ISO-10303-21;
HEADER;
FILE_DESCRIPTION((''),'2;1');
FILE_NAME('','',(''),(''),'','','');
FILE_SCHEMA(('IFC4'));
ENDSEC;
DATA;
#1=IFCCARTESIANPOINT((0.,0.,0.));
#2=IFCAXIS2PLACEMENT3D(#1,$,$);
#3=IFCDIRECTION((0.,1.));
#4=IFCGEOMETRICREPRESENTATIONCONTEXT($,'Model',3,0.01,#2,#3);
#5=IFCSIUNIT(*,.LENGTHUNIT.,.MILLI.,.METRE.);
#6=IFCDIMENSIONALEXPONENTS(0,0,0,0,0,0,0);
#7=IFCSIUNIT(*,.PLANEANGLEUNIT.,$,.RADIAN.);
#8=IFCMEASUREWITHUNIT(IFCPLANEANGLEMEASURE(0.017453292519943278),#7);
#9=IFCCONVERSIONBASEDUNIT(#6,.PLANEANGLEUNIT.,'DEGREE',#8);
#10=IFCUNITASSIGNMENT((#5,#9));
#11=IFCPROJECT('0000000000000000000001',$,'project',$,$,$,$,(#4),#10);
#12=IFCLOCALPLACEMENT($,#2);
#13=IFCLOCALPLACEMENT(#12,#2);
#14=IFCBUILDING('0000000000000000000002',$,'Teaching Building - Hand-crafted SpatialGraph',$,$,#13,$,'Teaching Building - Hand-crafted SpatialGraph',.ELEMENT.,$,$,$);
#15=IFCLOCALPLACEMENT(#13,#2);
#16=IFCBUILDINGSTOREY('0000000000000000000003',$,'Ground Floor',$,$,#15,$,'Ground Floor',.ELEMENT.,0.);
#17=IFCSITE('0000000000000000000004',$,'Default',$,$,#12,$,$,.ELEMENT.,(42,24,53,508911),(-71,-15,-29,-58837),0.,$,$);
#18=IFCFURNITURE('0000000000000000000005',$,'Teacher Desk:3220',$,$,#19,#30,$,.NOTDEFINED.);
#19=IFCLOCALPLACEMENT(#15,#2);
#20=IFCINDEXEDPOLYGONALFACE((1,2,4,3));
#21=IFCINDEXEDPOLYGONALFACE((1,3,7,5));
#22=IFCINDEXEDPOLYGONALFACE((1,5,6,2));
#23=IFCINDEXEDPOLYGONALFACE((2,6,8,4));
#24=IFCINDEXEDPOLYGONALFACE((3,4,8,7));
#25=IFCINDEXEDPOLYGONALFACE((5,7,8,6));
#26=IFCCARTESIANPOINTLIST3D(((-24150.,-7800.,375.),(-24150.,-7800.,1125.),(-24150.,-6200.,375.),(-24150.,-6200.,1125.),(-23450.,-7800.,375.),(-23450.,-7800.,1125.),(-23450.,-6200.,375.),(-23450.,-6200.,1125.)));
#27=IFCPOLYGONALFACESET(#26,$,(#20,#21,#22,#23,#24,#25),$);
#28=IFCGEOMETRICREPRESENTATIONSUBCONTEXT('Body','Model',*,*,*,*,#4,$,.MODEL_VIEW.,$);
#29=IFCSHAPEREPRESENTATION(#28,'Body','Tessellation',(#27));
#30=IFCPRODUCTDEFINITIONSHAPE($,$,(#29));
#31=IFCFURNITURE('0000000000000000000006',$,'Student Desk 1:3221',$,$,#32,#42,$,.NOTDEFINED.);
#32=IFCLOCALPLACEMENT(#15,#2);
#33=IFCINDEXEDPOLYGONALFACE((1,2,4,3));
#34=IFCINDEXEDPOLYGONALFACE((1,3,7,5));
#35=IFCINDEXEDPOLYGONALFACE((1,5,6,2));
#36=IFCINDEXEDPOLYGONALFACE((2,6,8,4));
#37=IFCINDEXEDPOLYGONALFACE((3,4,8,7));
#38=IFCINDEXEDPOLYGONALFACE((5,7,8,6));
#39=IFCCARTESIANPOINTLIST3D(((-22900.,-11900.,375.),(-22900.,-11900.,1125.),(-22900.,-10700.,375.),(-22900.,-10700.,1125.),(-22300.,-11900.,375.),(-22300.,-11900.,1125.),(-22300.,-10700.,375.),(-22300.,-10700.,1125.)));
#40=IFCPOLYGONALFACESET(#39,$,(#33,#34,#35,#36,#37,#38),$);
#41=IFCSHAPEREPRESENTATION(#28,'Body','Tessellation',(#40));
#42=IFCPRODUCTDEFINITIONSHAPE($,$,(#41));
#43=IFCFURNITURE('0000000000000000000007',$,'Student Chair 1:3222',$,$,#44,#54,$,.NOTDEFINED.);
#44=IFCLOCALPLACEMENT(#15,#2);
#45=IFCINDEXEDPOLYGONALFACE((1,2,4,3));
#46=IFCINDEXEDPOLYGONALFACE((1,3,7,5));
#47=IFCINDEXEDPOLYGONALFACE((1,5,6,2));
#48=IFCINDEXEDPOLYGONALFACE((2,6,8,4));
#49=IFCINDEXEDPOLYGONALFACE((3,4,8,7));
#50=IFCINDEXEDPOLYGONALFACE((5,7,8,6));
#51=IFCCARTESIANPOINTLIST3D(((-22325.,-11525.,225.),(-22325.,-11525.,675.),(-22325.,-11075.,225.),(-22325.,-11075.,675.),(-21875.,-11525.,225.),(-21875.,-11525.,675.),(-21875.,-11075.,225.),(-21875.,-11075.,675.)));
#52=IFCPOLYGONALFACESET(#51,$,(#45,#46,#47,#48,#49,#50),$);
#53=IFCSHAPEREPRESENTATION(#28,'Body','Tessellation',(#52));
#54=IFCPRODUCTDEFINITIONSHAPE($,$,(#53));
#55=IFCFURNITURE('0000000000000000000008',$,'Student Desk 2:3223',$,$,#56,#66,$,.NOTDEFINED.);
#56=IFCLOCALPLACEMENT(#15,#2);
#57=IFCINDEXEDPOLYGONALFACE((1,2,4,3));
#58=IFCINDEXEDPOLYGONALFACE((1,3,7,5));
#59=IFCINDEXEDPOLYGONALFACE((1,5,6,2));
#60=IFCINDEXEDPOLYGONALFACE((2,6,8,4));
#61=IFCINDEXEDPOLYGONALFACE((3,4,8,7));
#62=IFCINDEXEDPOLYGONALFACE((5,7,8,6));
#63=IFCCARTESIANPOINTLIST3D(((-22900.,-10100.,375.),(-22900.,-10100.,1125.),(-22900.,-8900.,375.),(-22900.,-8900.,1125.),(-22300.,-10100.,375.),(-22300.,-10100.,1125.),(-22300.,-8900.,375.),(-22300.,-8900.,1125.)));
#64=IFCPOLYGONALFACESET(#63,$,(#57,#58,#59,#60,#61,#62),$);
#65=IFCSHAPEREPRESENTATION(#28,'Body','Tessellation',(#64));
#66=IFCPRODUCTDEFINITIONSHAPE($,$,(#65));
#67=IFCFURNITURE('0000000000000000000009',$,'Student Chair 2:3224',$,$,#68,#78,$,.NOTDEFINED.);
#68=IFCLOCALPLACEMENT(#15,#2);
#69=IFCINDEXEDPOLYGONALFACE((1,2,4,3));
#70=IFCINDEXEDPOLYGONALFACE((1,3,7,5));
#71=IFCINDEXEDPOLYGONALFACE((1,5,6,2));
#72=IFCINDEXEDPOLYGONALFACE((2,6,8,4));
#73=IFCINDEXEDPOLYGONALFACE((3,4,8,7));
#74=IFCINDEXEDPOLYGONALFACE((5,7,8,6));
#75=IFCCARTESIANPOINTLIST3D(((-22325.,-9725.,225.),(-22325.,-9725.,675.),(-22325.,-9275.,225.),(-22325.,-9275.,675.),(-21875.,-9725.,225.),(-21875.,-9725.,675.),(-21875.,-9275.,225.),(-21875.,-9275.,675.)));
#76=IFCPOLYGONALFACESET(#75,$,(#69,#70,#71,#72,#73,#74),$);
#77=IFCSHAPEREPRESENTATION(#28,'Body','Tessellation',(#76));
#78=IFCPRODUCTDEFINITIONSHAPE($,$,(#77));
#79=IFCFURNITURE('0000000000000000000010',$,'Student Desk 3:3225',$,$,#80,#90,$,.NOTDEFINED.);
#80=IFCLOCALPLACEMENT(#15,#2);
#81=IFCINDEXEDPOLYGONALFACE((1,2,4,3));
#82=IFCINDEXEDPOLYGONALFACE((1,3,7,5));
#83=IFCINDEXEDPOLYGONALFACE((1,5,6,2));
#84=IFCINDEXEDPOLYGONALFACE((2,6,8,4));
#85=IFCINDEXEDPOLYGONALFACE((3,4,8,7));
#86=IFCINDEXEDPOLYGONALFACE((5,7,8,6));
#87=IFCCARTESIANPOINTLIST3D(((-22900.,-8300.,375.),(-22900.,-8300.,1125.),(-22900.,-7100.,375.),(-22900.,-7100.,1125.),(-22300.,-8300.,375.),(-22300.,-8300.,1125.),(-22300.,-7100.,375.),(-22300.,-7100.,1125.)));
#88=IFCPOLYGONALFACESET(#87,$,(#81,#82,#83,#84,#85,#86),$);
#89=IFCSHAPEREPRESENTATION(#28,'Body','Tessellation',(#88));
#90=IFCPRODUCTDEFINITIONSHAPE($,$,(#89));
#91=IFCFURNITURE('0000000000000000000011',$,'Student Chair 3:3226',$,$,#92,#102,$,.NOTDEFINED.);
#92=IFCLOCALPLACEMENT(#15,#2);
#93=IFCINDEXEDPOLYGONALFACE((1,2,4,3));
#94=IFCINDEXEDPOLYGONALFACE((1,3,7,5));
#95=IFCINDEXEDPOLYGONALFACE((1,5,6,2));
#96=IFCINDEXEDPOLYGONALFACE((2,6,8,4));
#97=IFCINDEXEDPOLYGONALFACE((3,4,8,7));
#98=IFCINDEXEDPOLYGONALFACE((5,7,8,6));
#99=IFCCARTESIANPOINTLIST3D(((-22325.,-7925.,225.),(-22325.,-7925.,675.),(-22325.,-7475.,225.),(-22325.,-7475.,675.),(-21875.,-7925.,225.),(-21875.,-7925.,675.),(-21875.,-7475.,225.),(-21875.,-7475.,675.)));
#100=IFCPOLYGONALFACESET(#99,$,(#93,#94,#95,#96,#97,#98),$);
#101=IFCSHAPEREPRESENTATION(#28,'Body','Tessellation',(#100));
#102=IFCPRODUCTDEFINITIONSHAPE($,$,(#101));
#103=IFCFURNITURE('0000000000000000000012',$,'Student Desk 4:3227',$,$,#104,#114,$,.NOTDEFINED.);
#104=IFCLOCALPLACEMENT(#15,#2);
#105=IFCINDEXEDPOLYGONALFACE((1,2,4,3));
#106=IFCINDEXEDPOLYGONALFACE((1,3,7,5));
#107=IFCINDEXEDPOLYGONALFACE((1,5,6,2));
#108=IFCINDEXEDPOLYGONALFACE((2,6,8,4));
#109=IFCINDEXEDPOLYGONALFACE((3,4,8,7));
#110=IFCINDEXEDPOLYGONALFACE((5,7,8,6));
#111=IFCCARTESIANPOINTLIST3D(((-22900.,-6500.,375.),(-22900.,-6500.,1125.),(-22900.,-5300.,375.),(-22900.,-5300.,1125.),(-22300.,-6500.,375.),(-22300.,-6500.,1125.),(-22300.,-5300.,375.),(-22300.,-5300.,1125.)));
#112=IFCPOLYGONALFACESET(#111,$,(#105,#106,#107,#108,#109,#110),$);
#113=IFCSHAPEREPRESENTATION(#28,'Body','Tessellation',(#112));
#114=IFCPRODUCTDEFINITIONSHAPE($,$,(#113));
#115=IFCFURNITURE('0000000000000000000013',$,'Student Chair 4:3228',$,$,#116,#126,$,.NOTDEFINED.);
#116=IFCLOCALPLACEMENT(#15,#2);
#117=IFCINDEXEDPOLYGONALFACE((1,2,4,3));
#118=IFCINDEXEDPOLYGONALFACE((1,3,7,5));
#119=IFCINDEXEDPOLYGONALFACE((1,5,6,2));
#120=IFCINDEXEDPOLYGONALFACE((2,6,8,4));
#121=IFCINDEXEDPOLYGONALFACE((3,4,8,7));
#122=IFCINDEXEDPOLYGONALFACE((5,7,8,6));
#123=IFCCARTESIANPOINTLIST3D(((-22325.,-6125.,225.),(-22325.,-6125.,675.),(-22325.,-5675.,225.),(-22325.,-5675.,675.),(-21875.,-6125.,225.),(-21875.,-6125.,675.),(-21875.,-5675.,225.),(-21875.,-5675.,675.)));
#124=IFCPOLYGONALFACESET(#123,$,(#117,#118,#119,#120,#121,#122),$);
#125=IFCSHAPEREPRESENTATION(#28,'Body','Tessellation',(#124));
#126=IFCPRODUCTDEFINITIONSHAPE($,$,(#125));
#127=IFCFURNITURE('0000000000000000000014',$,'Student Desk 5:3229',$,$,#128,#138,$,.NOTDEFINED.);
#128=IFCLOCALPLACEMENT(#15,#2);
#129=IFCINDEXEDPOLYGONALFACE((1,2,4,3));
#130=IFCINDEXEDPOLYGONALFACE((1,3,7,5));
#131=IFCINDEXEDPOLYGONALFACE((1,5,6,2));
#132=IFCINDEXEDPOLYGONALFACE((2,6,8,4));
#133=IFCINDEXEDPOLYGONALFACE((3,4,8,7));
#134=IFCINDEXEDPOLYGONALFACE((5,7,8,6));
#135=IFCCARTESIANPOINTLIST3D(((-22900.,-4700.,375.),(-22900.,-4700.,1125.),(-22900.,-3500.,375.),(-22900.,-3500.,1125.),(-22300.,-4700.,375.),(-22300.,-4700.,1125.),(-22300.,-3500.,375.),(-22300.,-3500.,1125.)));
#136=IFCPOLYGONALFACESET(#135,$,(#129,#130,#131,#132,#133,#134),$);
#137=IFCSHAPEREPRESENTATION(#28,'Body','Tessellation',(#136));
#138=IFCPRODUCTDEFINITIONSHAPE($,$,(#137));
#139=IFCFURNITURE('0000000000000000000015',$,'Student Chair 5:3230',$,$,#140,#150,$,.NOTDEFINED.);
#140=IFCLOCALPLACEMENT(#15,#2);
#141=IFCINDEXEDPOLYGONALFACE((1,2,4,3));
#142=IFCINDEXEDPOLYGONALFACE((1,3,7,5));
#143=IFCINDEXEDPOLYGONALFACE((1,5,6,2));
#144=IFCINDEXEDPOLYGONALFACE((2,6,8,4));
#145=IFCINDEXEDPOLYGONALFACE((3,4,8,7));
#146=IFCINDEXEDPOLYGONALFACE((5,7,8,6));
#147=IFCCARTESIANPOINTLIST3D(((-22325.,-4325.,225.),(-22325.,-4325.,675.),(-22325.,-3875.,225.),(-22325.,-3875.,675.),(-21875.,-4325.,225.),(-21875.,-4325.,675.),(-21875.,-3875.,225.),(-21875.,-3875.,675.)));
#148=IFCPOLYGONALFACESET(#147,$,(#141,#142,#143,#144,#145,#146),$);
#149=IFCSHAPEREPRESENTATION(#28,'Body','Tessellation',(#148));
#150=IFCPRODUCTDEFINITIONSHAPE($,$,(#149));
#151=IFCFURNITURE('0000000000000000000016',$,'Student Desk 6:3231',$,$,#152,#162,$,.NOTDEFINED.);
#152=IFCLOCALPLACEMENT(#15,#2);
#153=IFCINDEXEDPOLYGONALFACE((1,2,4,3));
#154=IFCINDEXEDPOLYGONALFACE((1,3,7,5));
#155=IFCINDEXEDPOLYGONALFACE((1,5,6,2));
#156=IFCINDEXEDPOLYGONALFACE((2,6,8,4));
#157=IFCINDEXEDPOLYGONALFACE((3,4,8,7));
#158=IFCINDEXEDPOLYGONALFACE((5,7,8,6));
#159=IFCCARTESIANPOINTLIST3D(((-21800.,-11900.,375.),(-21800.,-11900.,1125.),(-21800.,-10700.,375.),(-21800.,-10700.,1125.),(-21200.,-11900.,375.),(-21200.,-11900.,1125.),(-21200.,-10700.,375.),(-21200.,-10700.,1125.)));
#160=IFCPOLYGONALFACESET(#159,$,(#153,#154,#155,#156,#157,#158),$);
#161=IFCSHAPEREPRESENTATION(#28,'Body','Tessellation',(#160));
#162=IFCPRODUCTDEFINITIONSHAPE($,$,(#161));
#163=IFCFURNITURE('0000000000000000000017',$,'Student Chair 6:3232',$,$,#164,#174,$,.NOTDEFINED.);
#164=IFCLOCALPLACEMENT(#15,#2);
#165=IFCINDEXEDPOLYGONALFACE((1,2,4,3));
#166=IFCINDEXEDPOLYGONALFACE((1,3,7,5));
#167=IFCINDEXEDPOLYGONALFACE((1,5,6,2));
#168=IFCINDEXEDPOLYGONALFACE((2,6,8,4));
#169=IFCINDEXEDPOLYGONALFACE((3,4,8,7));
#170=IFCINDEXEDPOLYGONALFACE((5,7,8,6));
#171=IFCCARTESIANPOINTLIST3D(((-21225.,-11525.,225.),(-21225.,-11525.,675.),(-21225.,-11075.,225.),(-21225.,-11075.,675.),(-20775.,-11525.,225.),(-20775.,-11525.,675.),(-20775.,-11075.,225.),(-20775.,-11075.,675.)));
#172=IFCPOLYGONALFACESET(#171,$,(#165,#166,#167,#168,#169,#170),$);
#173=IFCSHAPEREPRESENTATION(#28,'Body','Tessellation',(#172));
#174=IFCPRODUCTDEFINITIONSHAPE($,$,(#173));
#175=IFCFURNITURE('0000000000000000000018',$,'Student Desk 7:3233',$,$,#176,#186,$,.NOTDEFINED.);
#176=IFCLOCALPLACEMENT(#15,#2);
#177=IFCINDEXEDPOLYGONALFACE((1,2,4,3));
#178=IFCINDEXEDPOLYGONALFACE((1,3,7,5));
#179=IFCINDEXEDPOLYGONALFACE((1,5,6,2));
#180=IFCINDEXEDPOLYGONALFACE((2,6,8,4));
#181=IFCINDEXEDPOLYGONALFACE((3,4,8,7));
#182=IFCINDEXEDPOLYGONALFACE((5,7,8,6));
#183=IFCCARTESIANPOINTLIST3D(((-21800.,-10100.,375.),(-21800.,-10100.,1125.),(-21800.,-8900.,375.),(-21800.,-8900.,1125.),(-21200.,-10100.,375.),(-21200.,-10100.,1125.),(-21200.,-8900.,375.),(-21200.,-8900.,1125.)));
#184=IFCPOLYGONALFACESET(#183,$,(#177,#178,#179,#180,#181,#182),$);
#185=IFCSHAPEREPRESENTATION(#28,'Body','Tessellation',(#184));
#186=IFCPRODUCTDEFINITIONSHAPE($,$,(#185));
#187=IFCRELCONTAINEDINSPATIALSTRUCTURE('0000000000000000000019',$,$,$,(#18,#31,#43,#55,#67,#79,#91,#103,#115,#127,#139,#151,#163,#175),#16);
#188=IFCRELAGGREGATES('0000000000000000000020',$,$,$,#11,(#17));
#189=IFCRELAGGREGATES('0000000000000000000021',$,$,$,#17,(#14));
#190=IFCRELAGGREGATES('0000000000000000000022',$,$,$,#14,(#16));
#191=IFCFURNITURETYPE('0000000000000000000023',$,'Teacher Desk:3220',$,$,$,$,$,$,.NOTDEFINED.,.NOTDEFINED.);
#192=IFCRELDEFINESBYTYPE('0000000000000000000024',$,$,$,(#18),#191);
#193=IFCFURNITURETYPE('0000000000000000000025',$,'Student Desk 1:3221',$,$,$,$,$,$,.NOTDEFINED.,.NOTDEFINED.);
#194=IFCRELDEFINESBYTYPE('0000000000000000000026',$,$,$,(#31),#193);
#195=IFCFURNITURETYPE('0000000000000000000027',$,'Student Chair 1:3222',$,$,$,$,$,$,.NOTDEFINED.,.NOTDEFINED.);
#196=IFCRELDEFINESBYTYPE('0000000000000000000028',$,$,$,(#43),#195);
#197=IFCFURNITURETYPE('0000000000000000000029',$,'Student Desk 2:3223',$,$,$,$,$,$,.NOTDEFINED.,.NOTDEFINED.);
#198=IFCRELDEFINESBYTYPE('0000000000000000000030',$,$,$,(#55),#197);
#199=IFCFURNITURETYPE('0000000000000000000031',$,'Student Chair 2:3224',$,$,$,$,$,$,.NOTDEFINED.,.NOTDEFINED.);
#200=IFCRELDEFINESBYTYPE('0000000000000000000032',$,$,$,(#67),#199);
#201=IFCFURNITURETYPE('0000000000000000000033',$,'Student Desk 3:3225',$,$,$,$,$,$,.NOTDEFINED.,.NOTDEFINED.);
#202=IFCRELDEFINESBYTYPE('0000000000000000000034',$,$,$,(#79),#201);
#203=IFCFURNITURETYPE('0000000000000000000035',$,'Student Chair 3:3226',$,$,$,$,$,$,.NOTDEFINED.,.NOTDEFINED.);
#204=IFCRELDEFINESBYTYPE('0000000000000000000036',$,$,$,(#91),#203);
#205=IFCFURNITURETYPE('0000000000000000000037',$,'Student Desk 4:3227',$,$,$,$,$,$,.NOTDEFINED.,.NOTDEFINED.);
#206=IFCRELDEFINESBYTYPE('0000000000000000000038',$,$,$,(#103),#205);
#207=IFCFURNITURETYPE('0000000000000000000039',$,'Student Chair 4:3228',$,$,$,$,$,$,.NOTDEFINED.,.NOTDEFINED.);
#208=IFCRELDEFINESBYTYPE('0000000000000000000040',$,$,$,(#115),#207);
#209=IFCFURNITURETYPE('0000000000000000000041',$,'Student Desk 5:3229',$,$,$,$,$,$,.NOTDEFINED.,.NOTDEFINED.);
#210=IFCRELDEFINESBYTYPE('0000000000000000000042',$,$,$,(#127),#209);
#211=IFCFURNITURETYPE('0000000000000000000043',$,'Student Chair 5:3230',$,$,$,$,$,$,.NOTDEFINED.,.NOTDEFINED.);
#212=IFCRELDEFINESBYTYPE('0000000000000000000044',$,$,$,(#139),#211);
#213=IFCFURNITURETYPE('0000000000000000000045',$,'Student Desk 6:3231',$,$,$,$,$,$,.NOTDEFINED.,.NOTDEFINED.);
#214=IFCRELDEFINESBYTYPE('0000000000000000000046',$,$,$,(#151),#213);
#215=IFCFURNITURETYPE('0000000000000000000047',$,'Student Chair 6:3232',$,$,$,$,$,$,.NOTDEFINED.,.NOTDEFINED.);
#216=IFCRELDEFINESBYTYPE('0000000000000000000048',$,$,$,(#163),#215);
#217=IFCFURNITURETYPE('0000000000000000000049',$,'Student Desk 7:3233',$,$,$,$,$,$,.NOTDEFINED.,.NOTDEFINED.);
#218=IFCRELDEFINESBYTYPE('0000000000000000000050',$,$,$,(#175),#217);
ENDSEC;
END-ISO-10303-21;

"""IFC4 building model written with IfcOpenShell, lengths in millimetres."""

from ifc_helpers import new_model, entity, si_unit, converted_unit, direction, frame, frame_2d, origin, origin_2d_with_axis, place, context, subcontext, project, spatial, rectangle, extrude, type_object, element, save


model = new_model("IFC4")

# Units and contexts
model_context = context("Model", 3, precision=0.01, world=origin(), true_north=direction((0.0, 1.0)))
body_context = subcontext(model_context, "Body", "Model", "MODEL_VIEW")
ifc_project = project(units=[si_unit("LENGTHUNIT", "METRE", prefix="MILLI"), converted_unit("PLANEANGLEUNIT", "DEGREE", entity("IfcPlaneAngleMeasure", 0.017453292519943278), si_unit("PLANEANGLEUNIT", "RADIAN"), dimensions=[0, 0, 0, 0, 0, 0, 0])], contexts=[model_context])

# Site, building, storey
site_placement = place(None, origin())
site = spatial("IfcSite", under=ifc_project, at=site_placement, Name="Default", CompositionType="ELEMENT", RefLatitude=(42, 24, 53, 508911), RefLongitude=(-71, -15, -29, -58837), RefElevation=0.0)
building_placement = place(site_placement, origin())
building = spatial("IfcBuilding", under=site, at=building_placement, Name="Teaching Building - Hand-crafted SpatialGraph", LongName="Teaching Building - Hand-crafted SpatialGraph", CompositionType="ELEMENT")
storey_placement = place(building_placement, origin())
storey = spatial("IfcBuildingStorey", under=building, at=storey_placement, Name="Ground Floor", LongName="Ground Floor", CompositionType="ELEMENT", Elevation=0.0)

# Furniture
furniture_type_1 = type_object("IfcFurnitureType", Name="Teacher Desk:3220", PredefinedType="NOTDEFINED")
furniture_1_placement = place(storey_placement, origin())
element("IfcFurniture", 1, at=furniture_1_placement, inside=storey, type_object=furniture_type_1, Name="Teacher Desk:3220", PredefinedType="NOTDEFINED", context=body_context, shape_type="SweptSolid", body=[
    extrude(rectangle(XDim=1600.0, YDim=700.0, at=origin_2d_with_axis()), frame((-23800.0, -7000.0, 375.0), z_axis=(0.0, 0.0, 1.0), x_axis=(0.0, 1.0, 0.0)), (0.0, 0.0, 1.0), 750.0),
])
furniture_type_2 = type_object("IfcFurnitureType", Name="Student Desk 1:3221", PredefinedType="NOTDEFINED")
furniture_2_placement = place(storey_placement, origin())
element("IfcFurniture", 2, at=furniture_2_placement, inside=storey, type_object=furniture_type_2, Name="Student Desk 1:3221", PredefinedType="NOTDEFINED", context=body_context, shape_type="SweptSolid", body=[
    extrude(rectangle(XDim=1200.0, YDim=600.0, at=origin_2d_with_axis()), frame((-22600.0, -11300.0, 375.0), z_axis=(0.0, 0.0, 1.0), x_axis=(0.0, 1.0, 0.0)), (0.0, 0.0, 1.0), 750.0),
])
furniture_type_3 = type_object("IfcFurnitureType", Name="Student Chair 1:3222", PredefinedType="NOTDEFINED")
furniture_3_placement = place(storey_placement, origin())
element("IfcFurniture", 3, at=furniture_3_placement, inside=storey, type_object=furniture_type_3, Name="Student Chair 1:3222", PredefinedType="NOTDEFINED", context=body_context, shape_type="SweptSolid", body=[
    extrude(rectangle(XDim=450.0, YDim=450.0, at=origin_2d_with_axis()), frame((-22100.0, -11300.0, 225.0)), (0.0, 0.0, 1.0), 450.0),
])
furniture_type_4 = type_object("IfcFurnitureType", Name="Student Desk 2:3223", PredefinedType="NOTDEFINED")
furniture_4_placement = place(storey_placement, origin())
element("IfcFurniture", 4, at=furniture_4_placement, inside=storey, type_object=furniture_type_4, Name="Student Desk 2:3223", PredefinedType="NOTDEFINED", context=body_context, shape_type="SweptSolid", body=[
    extrude(rectangle(XDim=1200.0, YDim=600.0, at=origin_2d_with_axis()), frame((-22600.0, -9500.0, 375.0), z_axis=(0.0, 0.0, 1.0), x_axis=(0.0, 1.0, 0.0)), (0.0, 0.0, 1.0), 750.0),
])
furniture_type_5 = type_object("IfcFurnitureType", Name="Student Chair 2:3224", PredefinedType="NOTDEFINED")
furniture_5_placement = place(storey_placement, origin())
element("IfcFurniture", 5, at=furniture_5_placement, inside=storey, type_object=furniture_type_5, Name="Student Chair 2:3224", PredefinedType="NOTDEFINED", context=body_context, shape_type="SweptSolid", body=[
    extrude(rectangle(XDim=450.0, YDim=450.0, at=origin_2d_with_axis()), frame((-22100.0, -9500.0, 225.0)), (0.0, 0.0, 1.0), 450.0),
])
furniture_type_6 = type_object("IfcFurnitureType", Name="Student Desk 3:3225", PredefinedType="NOTDEFINED")
furniture_6_placement = place(storey_placement, origin())
element("IfcFurniture", 6, at=furniture_6_placement, inside=storey, type_object=furniture_type_6, Name="Student Desk 3:3225", PredefinedType="NOTDEFINED", context=body_context, shape_type="SweptSolid", body=[
    extrude(rectangle(XDim=1200.0, YDim=600.0, at=origin_2d_with_axis()), frame((-22600.0, -7700.0, 375.0), z_axis=(0.0, 0.0, 1.0), x_axis=(0.0, 1.0, 0.0)), (0.0, 0.0, 1.0), 750.0),
])
furniture_type_7 = type_object("IfcFurnitureType", Name="Student Chair 3:3226", PredefinedType="NOTDEFINED")
furniture_7_placement = place(storey_placement, origin())
element("IfcFurniture", 7, at=furniture_7_placement, inside=storey, type_object=furniture_type_7, Name="Student Chair 3:3226", PredefinedType="NOTDEFINED", context=body_context, shape_type="SweptSolid", body=[
    extrude(rectangle(XDim=450.0, YDim=450.0, at=frame_2d((0.0, 0.0), x_axis=(1.0, 0.0))), frame((-22100.0, -7700.0, 225.0)), (0.0, 0.0, 1.0), 450.0),
])
furniture_type_8 = type_object("IfcFurnitureType", Name="Student Desk 4:3227", PredefinedType="NOTDEFINED")
furniture_8_placement = place(storey_placement, origin())
element("IfcFurniture", 8, at=furniture_8_placement, inside=storey, type_object=furniture_type_8, Name="Student Desk 4:3227", PredefinedType="NOTDEFINED", context=body_context, shape_type="SweptSolid", body=[
    extrude(rectangle(XDim=1200.0, YDim=600.0, at=origin_2d_with_axis()), frame((-22600.0, -5900.0, 375.0), z_axis=(0.0, 0.0, 1.0), x_axis=(0.0, 1.0, 0.0)), (0.0, 0.0, 1.0), 750.0),
])
furniture_type_9 = type_object("IfcFurnitureType", Name="Student Chair 4:3228", PredefinedType="NOTDEFINED")
furniture_9_placement = place(storey_placement, origin())
element("IfcFurniture", 9, at=furniture_9_placement, inside=storey, type_object=furniture_type_9, Name="Student Chair 4:3228", PredefinedType="NOTDEFINED", context=body_context, shape_type="SweptSolid", body=[
    extrude(rectangle(XDim=450.0, YDim=450.0, at=origin_2d_with_axis()), frame((-22100.0, -5900.0, 225.0)), (0.0, 0.0, 1.0), 450.0),
])
furniture_type_10 = type_object("IfcFurnitureType", Name="Student Desk 5:3229", PredefinedType="NOTDEFINED")
furniture_10_placement = place(storey_placement, origin())
element("IfcFurniture", 10, at=furniture_10_placement, inside=storey, type_object=furniture_type_10, Name="Student Desk 5:3229", PredefinedType="NOTDEFINED", context=body_context, shape_type="SweptSolid", body=[
    extrude(rectangle(XDim=1200.0, YDim=600.0, at=origin_2d_with_axis()), frame((-22600.0, -4100.0, 375.0), z_axis=(0.0, 0.0, 1.0), x_axis=(0.0, 1.0, 0.0)), (0.0, 0.0, 1.0), 750.0),
])
furniture_type_11 = type_object("IfcFurnitureType", Name="Student Chair 5:3230", PredefinedType="NOTDEFINED")
furniture_11_placement = place(storey_placement, origin())
element("IfcFurniture", 11, at=furniture_11_placement, inside=storey, type_object=furniture_type_11, Name="Student Chair 5:3230", PredefinedType="NOTDEFINED", context=body_context, shape_type="SweptSolid", body=[
    extrude(rectangle(XDim=450.0, YDim=450.0, at=origin_2d_with_axis()), frame((-22100.0, -4100.0, 225.0)), (0.0, 0.0, 1.0), 450.0),
])
furniture_type_12 = type_object("IfcFurnitureType", Name="Student Desk 6:3231", PredefinedType="NOTDEFINED")
furniture_12_placement = place(storey_placement, origin())
element("IfcFurniture", 12, at=furniture_12_placement, inside=storey, type_object=furniture_type_12, Name="Student Desk 6:3231", PredefinedType="NOTDEFINED", context=body_context, shape_type="SweptSolid", body=[
    extrude(rectangle(XDim=1200.0, YDim=600.0, at=origin_2d_with_axis()), frame((-21500.0, -11300.0, 375.0), z_axis=(0.0, 0.0, 1.0), x_axis=(0.0, 1.0, 0.0)), (0.0, 0.0, 1.0), 750.0),
])
furniture_type_13 = type_object("IfcFurnitureType", Name="Student Chair 6:3232", PredefinedType="NOTDEFINED")
furniture_13_placement = place(storey_placement, origin())
element("IfcFurniture", 13, at=furniture_13_placement, inside=storey, type_object=furniture_type_13, Name="Student Chair 6:3232", PredefinedType="NOTDEFINED", context=body_context, shape_type="SweptSolid", body=[
    extrude(rectangle(XDim=450.0, YDim=450.0, at=origin_2d_with_axis()), frame((-21000.0, -11300.0, 225.0)), (0.0, 0.0, 1.0), 450.0),
])
furniture_type_14 = type_object("IfcFurnitureType", Name="Student Desk 7:3233", PredefinedType="NOTDEFINED")
furniture_14_placement = place(storey_placement, origin())
element("IfcFurniture", 14, at=furniture_14_placement, inside=storey, type_object=furniture_type_14, Name="Student Desk 7:3233", PredefinedType="NOTDEFINED", context=body_context, shape_type="SweptSolid", body=[
    extrude(rectangle(XDim=1200.0, YDim=600.0, at=origin_2d_with_axis()), frame((-21500.0, -9500.0, 375.0), z_axis=(0.0, 0.0, 1.0), x_axis=(0.0, 1.0, 0.0)), (0.0, 0.0, 1.0), 750.0),
])

save(model, "model.ifc")
